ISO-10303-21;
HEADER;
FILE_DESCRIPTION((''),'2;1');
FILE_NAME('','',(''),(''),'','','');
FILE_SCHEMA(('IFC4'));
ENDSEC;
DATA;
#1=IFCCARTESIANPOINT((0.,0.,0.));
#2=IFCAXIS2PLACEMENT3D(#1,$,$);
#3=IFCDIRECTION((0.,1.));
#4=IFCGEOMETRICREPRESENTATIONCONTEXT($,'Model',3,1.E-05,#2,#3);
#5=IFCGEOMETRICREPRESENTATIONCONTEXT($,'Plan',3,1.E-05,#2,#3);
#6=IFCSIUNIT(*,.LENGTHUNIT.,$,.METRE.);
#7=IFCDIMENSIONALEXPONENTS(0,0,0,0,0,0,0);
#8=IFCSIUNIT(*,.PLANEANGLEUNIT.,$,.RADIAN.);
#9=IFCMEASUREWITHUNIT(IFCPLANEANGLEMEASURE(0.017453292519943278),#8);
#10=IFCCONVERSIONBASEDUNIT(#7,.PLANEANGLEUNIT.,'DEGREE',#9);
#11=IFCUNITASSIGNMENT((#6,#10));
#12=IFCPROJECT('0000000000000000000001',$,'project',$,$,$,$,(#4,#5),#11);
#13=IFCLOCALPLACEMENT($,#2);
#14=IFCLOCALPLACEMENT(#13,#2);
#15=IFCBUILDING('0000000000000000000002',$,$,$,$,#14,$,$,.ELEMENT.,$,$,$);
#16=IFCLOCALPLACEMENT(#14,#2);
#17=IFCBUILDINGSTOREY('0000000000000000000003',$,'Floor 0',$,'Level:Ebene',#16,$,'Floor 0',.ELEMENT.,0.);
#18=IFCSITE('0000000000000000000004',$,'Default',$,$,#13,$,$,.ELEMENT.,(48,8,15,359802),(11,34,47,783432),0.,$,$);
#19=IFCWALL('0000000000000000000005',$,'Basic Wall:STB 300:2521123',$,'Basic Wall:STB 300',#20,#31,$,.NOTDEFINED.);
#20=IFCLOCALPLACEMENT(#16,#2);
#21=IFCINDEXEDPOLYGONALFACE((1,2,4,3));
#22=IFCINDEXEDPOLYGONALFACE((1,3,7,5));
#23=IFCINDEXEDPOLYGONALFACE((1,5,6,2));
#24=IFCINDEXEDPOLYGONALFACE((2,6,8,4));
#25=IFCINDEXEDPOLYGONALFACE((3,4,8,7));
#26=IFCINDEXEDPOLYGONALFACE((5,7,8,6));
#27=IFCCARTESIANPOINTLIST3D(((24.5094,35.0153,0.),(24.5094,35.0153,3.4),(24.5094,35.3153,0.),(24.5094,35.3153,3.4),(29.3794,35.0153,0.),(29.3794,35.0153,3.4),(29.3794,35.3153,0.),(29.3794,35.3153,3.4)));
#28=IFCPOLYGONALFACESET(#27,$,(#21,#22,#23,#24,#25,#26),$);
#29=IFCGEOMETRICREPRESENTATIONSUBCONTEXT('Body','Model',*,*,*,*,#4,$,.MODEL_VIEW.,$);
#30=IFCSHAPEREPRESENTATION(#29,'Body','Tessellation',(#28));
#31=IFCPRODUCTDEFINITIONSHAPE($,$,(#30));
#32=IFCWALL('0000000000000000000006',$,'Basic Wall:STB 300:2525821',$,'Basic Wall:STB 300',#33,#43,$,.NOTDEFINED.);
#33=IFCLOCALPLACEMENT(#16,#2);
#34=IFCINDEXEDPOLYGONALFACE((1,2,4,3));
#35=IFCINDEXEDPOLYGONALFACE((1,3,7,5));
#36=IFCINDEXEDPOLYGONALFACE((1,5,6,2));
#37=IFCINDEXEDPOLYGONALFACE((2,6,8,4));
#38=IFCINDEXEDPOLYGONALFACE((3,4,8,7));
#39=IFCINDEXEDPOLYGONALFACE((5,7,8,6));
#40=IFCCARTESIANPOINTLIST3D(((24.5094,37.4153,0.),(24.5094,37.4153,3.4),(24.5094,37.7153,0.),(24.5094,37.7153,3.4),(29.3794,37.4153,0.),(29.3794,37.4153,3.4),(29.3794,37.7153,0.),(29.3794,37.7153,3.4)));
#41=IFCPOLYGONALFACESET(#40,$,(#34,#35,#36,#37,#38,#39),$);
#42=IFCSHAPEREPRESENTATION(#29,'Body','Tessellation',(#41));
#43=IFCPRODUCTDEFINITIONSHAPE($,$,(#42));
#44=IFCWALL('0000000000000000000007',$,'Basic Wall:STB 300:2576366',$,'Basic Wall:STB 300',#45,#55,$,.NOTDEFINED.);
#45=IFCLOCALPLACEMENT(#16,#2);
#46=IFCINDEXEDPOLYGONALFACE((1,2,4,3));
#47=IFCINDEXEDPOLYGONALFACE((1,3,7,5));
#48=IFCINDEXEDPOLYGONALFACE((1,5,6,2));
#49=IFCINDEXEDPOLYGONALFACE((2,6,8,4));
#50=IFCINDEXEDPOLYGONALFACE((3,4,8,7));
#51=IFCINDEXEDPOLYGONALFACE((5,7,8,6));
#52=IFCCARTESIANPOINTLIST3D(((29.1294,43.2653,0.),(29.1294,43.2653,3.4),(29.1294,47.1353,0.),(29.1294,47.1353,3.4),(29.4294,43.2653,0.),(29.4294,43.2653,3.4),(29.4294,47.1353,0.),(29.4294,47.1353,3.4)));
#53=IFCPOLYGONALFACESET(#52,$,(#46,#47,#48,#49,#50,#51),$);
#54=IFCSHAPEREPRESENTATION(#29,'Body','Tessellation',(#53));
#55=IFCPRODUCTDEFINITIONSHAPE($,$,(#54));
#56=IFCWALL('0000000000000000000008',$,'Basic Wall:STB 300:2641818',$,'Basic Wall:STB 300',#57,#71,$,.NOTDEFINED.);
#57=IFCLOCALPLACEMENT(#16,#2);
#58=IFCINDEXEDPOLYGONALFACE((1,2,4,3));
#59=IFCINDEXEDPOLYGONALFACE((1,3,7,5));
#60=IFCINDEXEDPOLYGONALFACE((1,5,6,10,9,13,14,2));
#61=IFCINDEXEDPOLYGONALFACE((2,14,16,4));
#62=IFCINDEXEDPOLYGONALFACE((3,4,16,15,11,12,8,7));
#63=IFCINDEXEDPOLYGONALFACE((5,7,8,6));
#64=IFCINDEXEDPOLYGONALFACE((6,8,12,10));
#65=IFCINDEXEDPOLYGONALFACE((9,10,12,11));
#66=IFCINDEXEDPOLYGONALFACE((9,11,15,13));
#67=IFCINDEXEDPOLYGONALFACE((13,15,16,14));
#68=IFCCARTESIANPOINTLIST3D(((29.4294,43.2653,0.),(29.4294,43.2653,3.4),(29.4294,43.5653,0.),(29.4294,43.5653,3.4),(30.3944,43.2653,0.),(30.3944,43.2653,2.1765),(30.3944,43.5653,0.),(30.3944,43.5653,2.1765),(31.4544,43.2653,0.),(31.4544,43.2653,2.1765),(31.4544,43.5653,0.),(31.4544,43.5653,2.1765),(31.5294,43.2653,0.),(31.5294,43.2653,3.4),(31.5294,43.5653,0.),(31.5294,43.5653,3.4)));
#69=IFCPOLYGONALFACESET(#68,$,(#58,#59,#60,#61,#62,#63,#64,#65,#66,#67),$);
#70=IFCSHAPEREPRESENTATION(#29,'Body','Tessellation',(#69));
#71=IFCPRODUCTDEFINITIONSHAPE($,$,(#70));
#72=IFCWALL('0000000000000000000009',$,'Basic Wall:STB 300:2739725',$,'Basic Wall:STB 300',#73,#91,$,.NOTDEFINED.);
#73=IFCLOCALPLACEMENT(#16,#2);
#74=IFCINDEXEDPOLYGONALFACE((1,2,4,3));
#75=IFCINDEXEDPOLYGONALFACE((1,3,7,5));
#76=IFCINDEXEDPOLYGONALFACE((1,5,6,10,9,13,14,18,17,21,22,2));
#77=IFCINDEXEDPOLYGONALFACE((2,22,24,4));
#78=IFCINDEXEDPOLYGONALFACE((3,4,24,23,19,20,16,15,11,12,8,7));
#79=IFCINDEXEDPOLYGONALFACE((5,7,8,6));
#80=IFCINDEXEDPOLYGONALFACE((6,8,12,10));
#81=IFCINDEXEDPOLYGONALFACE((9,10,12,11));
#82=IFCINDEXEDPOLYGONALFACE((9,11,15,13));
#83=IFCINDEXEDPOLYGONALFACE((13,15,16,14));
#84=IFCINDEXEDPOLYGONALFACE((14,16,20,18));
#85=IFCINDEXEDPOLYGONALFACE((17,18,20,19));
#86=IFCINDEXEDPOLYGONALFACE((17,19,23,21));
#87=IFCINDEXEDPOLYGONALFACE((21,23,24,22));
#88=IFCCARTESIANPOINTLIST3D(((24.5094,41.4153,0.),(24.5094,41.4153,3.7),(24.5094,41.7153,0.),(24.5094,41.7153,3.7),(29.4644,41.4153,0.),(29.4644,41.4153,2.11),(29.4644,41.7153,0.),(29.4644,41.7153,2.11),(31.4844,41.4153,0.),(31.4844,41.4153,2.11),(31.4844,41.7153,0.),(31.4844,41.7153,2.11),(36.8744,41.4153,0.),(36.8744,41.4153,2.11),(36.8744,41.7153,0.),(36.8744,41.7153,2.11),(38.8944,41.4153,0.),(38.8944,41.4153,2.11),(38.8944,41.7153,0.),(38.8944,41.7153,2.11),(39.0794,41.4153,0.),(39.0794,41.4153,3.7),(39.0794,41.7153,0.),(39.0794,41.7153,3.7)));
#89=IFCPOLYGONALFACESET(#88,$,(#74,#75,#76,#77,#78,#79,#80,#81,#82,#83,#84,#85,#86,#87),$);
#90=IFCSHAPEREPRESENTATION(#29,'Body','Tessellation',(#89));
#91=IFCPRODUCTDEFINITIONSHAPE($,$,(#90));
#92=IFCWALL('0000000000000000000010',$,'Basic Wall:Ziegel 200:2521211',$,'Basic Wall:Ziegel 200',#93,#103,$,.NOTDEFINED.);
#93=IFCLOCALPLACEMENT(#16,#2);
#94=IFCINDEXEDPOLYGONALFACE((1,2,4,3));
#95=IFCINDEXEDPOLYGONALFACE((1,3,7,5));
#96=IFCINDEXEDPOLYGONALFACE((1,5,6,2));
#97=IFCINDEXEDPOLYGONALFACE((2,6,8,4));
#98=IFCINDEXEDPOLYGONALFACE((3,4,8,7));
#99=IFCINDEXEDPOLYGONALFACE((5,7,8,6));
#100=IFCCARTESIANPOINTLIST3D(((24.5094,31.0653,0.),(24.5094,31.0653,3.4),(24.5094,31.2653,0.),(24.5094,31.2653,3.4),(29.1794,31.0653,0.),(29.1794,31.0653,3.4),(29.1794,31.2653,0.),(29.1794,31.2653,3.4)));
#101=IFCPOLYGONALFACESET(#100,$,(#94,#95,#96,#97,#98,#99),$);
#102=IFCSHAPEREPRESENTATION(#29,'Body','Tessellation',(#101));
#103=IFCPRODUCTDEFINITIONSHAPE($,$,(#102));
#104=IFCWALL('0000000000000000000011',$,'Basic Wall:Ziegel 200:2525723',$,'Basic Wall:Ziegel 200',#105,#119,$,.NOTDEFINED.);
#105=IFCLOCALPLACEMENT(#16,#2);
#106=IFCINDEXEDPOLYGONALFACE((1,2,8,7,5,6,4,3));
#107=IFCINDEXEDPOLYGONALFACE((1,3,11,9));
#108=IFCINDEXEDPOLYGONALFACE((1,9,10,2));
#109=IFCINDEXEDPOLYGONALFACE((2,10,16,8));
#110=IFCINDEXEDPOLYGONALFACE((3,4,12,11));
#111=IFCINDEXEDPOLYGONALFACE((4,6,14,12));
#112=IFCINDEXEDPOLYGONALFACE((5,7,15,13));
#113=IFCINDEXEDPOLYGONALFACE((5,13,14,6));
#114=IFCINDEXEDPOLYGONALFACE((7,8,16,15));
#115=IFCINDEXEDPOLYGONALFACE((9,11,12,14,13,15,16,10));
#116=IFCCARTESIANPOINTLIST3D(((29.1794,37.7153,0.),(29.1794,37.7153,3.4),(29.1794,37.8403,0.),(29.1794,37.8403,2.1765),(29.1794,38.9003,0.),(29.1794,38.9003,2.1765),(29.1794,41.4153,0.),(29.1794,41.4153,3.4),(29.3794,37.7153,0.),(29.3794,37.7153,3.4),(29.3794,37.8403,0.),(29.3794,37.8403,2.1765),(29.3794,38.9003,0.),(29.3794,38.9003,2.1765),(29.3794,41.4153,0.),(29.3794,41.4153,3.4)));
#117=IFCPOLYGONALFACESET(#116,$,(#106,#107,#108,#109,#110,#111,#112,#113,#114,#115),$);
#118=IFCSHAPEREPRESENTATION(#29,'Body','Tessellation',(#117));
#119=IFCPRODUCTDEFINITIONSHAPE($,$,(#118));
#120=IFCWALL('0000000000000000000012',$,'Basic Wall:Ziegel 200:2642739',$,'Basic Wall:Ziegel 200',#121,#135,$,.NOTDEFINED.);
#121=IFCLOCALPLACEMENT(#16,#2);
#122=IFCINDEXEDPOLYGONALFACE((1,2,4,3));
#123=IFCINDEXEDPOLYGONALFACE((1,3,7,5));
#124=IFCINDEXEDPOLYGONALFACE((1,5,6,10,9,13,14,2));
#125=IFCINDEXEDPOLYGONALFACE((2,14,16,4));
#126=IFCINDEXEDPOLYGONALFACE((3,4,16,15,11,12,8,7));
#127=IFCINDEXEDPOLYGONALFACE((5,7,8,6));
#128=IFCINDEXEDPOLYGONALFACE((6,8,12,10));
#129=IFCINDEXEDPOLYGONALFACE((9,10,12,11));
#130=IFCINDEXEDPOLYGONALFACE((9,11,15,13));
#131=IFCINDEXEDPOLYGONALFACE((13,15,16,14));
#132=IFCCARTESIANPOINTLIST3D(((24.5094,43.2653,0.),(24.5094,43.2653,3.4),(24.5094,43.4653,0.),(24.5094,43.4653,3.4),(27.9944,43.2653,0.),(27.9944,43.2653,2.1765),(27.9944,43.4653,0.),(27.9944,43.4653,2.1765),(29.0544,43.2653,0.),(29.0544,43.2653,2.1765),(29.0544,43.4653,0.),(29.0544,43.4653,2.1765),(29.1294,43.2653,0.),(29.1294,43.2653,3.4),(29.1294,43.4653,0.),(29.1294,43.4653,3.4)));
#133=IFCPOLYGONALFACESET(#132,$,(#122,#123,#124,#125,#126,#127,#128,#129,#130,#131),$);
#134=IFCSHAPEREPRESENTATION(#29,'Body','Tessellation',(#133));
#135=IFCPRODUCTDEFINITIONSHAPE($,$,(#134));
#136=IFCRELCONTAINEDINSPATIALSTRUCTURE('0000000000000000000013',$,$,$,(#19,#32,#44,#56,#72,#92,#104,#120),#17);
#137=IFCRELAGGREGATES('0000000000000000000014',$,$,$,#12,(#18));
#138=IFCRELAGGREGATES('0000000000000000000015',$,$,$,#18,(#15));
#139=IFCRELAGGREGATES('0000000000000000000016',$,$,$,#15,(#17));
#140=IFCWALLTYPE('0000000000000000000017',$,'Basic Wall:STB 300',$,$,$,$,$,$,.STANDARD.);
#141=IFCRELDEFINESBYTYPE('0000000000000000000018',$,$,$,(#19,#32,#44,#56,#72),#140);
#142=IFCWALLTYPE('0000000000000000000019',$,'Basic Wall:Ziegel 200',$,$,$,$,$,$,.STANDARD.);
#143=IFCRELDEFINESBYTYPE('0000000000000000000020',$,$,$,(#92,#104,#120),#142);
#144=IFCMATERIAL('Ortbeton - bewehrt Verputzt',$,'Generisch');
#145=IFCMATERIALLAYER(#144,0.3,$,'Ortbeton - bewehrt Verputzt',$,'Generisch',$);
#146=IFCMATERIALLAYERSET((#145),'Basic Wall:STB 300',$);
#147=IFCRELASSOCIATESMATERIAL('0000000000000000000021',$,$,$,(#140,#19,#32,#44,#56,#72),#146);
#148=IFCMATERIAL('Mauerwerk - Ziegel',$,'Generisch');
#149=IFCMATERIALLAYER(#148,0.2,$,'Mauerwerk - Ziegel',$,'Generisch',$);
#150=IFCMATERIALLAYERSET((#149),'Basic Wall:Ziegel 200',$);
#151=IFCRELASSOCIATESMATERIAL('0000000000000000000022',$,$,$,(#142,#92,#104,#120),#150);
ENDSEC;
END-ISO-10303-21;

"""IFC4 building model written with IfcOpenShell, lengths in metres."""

from ifc_helpers import new_model, entity, si_unit, converted_unit, direction, frame, frame_2d, origin, place, context, subcontext, project, spatial, polyline, rectangle, extrude, clip, bounded_halfspace, material, layer, layer_set, layer_usage, type_object, element, save


model = new_model("IFC4")

# Units and contexts
model_context = context("Model", 3, precision=1e-05, world=origin(), true_north=direction((0.0, 1.0)))
plan_context = context("Plan", 3, precision=1e-05, world=origin(), true_north=direction((0.0, 1.0)))
body_context = subcontext(model_context, "Body", "Model", "MODEL_VIEW")
ifc_project = project(units=[si_unit("LENGTHUNIT", "METRE"), converted_unit("PLANEANGLEUNIT", "DEGREE", entity("IfcPlaneAngleMeasure", 0.017453292519943278), si_unit("PLANEANGLEUNIT", "RADIAN"), dimensions=[0, 0, 0, 0, 0, 0, 0])], contexts=[model_context, plan_context])

# Site, building, storey
site_placement = place(None, origin())
site = spatial("IfcSite", under=ifc_project, at=site_placement, Name="Default", CompositionType="ELEMENT", RefLatitude=(48, 8, 15, 359802), RefLongitude=(11, 34, 47, 783432), RefElevation=0.0)
building_placement = place(site_placement, origin())
building = spatial("IfcBuilding", under=site, at=building_placement, CompositionType="ELEMENT")
storey_placement = place(building_placement, origin())
storey = spatial("IfcBuildingStorey", under=building, at=storey_placement, Name="Floor 0", ObjectType="Level:Ebene", LongName="Floor 0", CompositionType="ELEMENT", Elevation=0.0)

# Walls
ifc_material_1 = material(Name="Ortbeton - bewehrt Verputzt", Category="Generisch")
ifc_layer_1 = layer(ifc_material_1, 0.3, Name="Ortbeton - bewehrt Verputzt", Category="Generisch")
ifc_layer_set_1 = layer_set([ifc_layer_1], Name="Basic Wall:STB 300")
ifc_layer_usage_1 = layer_usage(ifc_layer_set_1, "AXIS2", "NEGATIVE", 0.15)
wall_type_1 = type_object("IfcWallType", Name="Basic Wall:STB 300", PredefinedType="STANDARD", material=ifc_layer_set_1)
wall_1_placement = place(storey_placement, frame((29.3794, 35.1653, 0.0), z_axis=(0.0, 0.0, 1.0), x_axis=(-1.0, 0.0, 0.0)))
element("IfcWall", 1, at=wall_1_placement, inside=storey, type_object=wall_type_1, material=ifc_layer_usage_1, Name="Basic Wall:STB 300:2521123", ObjectType="Basic Wall:STB 300", PredefinedType="NOTDEFINED", context=body_context, shape_type="Clipping", body=[
    clip(extrude(rectangle(XDim=4.87, YDim=0.3, at=frame_2d((2.435, 0.0), x_axis=(-1.0, 0.0))), origin(), (0.0, 0.0, 1.0), 3.4), bounded_halfspace(frame((0.0, -0.15, 3.4), z_axis=(0.0, 0.0, -1.0), x_axis=(1.0, 0.0, 0.0)), True, frame((0.0, -0.15, 3.4)), polyline([(0.0, 0.0), (1.4554, 0.0), (4.87, 0.0), (4.87, 0.3), (0.0, 0.3), (0.0, 0.0)]))),
])
wall_2_placement = place(storey_placement, frame((29.3794, 37.5653, 0.0), z_axis=(0.0, 0.0, 1.0), x_axis=(-1.0, 0.0, 0.0)))
element("IfcWall", 2, at=wall_2_placement, inside=storey, type_object=wall_type_1, material=ifc_layer_usage_1, Name="Basic Wall:STB 300:2525821", ObjectType="Basic Wall:STB 300", PredefinedType="NOTDEFINED", context=body_context, shape_type="Clipping", body=[
    clip(extrude(rectangle(XDim=4.87, YDim=0.3, at=frame_2d((2.435, 0.0), x_axis=(-1.0, 0.0))), origin(), (0.0, 0.0, 1.0), 3.4), bounded_halfspace(frame((0.0, -0.15, 3.4), z_axis=(0.0, 0.0, -1.0), x_axis=(1.0, 0.0, 0.0)), True, frame((0.0, -0.15, 3.4)), polyline([(0.0, 0.0), (4.87, 0.0), (4.87, 0.3), (0.0, 0.3), (0.0, 0.0)]))),
])
wall_3_placement = place(storey_placement, frame((29.2794, 43.2653, 0.0), z_axis=(0.0, 0.0, 1.0), x_axis=(0.0, 1.0, 0.0)))
element("IfcWall", 3, at=wall_3_placement, inside=storey, type_object=wall_type_1, material=ifc_layer_usage_1, Name="Basic Wall:STB 300:2576366", ObjectType="Basic Wall:STB 300", PredefinedType="NOTDEFINED", context=body_context, shape_type="Clipping", body=[
    clip(extrude(rectangle(XDim=3.87, YDim=0.3, at=frame_2d((1.935, 0.0), x_axis=(-1.0, 0.0))), origin(), (0.0, 0.0, 1.0), 3.4), bounded_halfspace(frame((0.0, -0.15, 3.4), z_axis=(0.0, 0.0, -1.0), x_axis=(0.0, 1.0, 0.0)), True, frame((0.0, -0.15, 3.4)), polyline([(0.0, 0.0), (0.3, 0.0), (3.87, 0.0), (3.87, 0.3), (0.0, 0.3), (0.0, 0.0)]))),
])

# Wall, opening
wall_4_placement = place(storey_placement, frame((29.4294, 43.4153, 0.0)))
wall_4 = element("IfcWall", 4, at=wall_4_placement, inside=storey, type_object=wall_type_1, material=ifc_layer_usage_1, Name="Basic Wall:STB 300:2641818", ObjectType="Basic Wall:STB 300", PredefinedType="NOTDEFINED", context=body_context, shape_type="Clipping", body=[
    clip(extrude(rectangle(XDim=2.1, YDim=0.3, at=frame_2d((1.05, 0.0), x_axis=(1.0, 0.0))), origin(), (0.0, 0.0, 1.0), 3.4), bounded_halfspace(frame((0.0, -0.15, 3.4), z_axis=(0.0, 0.0, -1.0), x_axis=(-1.0, 0.0, 0.0)), True, frame((0.0, -0.15, 3.4)), polyline([(0.0, 0.0), (2.1, 0.0), (2.1, 0.3), (0.0, 0.3), (0.0, 0.0)]))),
])
opening_1_placement = place(wall_4_placement, frame((0.965, -0.15, 0.0)))
element("IfcOpeningElement", 5, at=opening_1_placement, cuts=wall_4, PredefinedType="OPENING", context=body_context, shape_type="SweptSolid", body=[
    extrude(rectangle(XDim=2.1765, YDim=1.06, at=frame_2d((1.0882, 0.53), x_axis=(1.0, 0.0))), frame((0.0, 0.0, 0.0), z_axis=(0.0, 1.0, 0.0), x_axis=(0.0, 0.0, 1.0)), (0.0, 0.0, 1.0), 0.3),
])

# Wall, openings
wall_5_placement = place(storey_placement, frame((24.5094, 41.5653, 0.0)))
wall_5 = element("IfcWall", 6, at=wall_5_placement, inside=storey, type_object=wall_type_1, material=ifc_layer_usage_1, Name="Basic Wall:STB 300:2739725", ObjectType="Basic Wall:STB 300", PredefinedType="NOTDEFINED", context=body_context, shape_type="SweptSolid", body=[
    extrude(rectangle(XDim=14.57, YDim=0.3, at=frame_2d((7.285, 0.0), x_axis=(-1.0, 0.0))), origin(), (0.0, 0.0, 1.0), 3.7),
])
opening_2_placement = place(wall_5_placement, frame((14.385, 0.15, 0.0)))
element("IfcOpeningElement", 7, at=opening_2_placement, cuts=wall_5, PredefinedType="OPENING", context=body_context, shape_type="SweptSolid", body=[
    extrude(rectangle(XDim=2.11, YDim=2.02, at=frame_2d((1.055, 1.01), x_axis=(1.0, 0.0))), frame((0.0, 0.0, 0.0), z_axis=(0.0, -1.0, 0.0), x_axis=(0.0, 0.0, 1.0)), (0.0, 0.0, 1.0), 0.3),
])
opening_3_placement = place(wall_5_placement, frame((6.975, 0.15, 0.0)))
element("IfcOpeningElement", 8, at=opening_3_placement, cuts=wall_5, PredefinedType="OPENING", context=body_context, shape_type="SweptSolid", body=[
    extrude(rectangle(XDim=2.11, YDim=2.02, at=frame_2d((1.055, 1.01), x_axis=(1.0, 0.0))), frame((0.0, 0.0, 0.0), z_axis=(0.0, -1.0, 0.0), x_axis=(0.0, 0.0, 1.0)), (0.0, 0.0, 1.0), 0.3),
])

# Wall
ifc_material_2 = material(Name="Mauerwerk - Ziegel", Category="Generisch")
ifc_layer_2 = layer(ifc_material_2, 0.2, Name="Mauerwerk - Ziegel", Category="Generisch")
ifc_layer_set_2 = layer_set([ifc_layer_2], Name="Basic Wall:Ziegel 200")
ifc_layer_usage_2 = layer_usage(ifc_layer_set_2, "AXIS2", "NEGATIVE", 0.1)
wall_type_2 = type_object("IfcWallType", Name="Basic Wall:Ziegel 200", PredefinedType="STANDARD", material=ifc_layer_set_2)
wall_6_placement = place(storey_placement, frame((29.1794, 31.1653, 0.0), z_axis=(0.0, 0.0, 1.0), x_axis=(-1.0, 0.0, 0.0)))
element("IfcWall", 9, at=wall_6_placement, inside=storey, type_object=wall_type_2, material=ifc_layer_usage_2, Name="Basic Wall:Ziegel 200:2521211", ObjectType="Basic Wall:Ziegel 200", PredefinedType="NOTDEFINED", context=body_context, shape_type="Clipping", body=[
    clip(extrude(rectangle(XDim=4.67, YDim=0.2, at=frame_2d((2.335, 0.0), x_axis=(-1.0, 0.0))), origin(), (0.0, 0.0, 1.0), 3.4), bounded_halfspace(frame((0.0, -0.1, 3.4), z_axis=(0.0, 0.0, -1.0), x_axis=(1.0, 0.0, 0.0)), True, frame((0.0, -0.1, 3.4)), polyline([(0.0, 0.0), (4.67, 0.0), (4.67, 0.2), (0.0, 0.2), (0.0, 0.0)]))),
])

# Walls, openings
wall_7_placement = place(storey_placement, frame((29.2794, 41.4153, 0.0), z_axis=(0.0, 0.0, 1.0), x_axis=(0.0, -1.0, 0.0)))
wall_7 = element("IfcWall", 10, at=wall_7_placement, inside=storey, type_object=wall_type_2, material=ifc_layer_usage_2, Name="Basic Wall:Ziegel 200:2525723", ObjectType="Basic Wall:Ziegel 200", PredefinedType="NOTDEFINED", context=body_context, shape_type="Clipping", body=[
    clip(extrude(rectangle(XDim=3.7, YDim=0.2, at=frame_2d((1.85, 0.0), x_axis=(-1.0, 0.0))), origin(), (0.0, 0.0, 1.0), 3.4), bounded_halfspace(frame((0.0, -0.1, 3.4), z_axis=(0.0, 0.0, -1.0), x_axis=(0.0, -1.0, 0.0)), True, frame((0.0, -0.1, 3.4)), polyline([(0.0, 0.0), (3.7, 0.0), (3.7, 0.2), (0.0, 0.2), (0.0, 0.0)]))),
])
opening_4_placement = place(wall_7_placement, frame((2.515, -0.1, 0.0)))
element("IfcOpeningElement", 11, at=opening_4_placement, cuts=wall_7, PredefinedType="OPENING", context=body_context, shape_type="SweptSolid", body=[
    extrude(rectangle(XDim=2.1765, YDim=1.06, at=frame_2d((1.0882, 0.53), x_axis=(1.0, 0.0))), frame((0.0, 0.0, 0.0), z_axis=(0.0, 1.0, 0.0), x_axis=(0.0, 0.0, 1.0)), (0.0, 0.0, 1.0), 0.2),
])
wall_8_placement = place(storey_placement, frame((24.5094, 43.3653, 0.0)))
wall_8 = element("IfcWall", 12, at=wall_8_placement, inside=storey, type_object=wall_type_2, material=ifc_layer_usage_2, Name="Basic Wall:Ziegel 200:2642739", ObjectType="Basic Wall:Ziegel 200", PredefinedType="NOTDEFINED", context=body_context, shape_type="Clipping", body=[
    clip(extrude(rectangle(XDim=4.62, YDim=0.2, at=frame_2d((2.31, 0.0), x_axis=(-1.0, 0.0))), origin(), (0.0, 0.0, 1.0), 3.4), bounded_halfspace(frame((0.0, -0.1, 3.4), z_axis=(0.0, 0.0, -1.0), x_axis=(-1.0, 0.0, 0.0)), True, frame((0.0, -0.1, 3.4)), polyline([(0.0, 0.0), (4.62, 0.0), (4.62, 0.2), (0.0, 0.2), (0.0, 0.0)]))),
])
opening_5_placement = place(wall_8_placement, frame((4.545, 0.1, 0.0)))
element("IfcOpeningElement", 13, at=opening_5_placement, cuts=wall_8, PredefinedType="OPENING", context=body_context, shape_type="SweptSolid", body=[
    extrude(rectangle(XDim=2.1765, YDim=1.06, at=frame_2d((1.0882, 0.53), x_axis=(1.0, 0.0))), frame((0.0, 0.0, 0.0), z_axis=(0.0, -1.0, 0.0), x_axis=(0.0, 0.0, 1.0)), (0.0, 0.0, 1.0), 0.2),
])

save(model, "model.ifc")
